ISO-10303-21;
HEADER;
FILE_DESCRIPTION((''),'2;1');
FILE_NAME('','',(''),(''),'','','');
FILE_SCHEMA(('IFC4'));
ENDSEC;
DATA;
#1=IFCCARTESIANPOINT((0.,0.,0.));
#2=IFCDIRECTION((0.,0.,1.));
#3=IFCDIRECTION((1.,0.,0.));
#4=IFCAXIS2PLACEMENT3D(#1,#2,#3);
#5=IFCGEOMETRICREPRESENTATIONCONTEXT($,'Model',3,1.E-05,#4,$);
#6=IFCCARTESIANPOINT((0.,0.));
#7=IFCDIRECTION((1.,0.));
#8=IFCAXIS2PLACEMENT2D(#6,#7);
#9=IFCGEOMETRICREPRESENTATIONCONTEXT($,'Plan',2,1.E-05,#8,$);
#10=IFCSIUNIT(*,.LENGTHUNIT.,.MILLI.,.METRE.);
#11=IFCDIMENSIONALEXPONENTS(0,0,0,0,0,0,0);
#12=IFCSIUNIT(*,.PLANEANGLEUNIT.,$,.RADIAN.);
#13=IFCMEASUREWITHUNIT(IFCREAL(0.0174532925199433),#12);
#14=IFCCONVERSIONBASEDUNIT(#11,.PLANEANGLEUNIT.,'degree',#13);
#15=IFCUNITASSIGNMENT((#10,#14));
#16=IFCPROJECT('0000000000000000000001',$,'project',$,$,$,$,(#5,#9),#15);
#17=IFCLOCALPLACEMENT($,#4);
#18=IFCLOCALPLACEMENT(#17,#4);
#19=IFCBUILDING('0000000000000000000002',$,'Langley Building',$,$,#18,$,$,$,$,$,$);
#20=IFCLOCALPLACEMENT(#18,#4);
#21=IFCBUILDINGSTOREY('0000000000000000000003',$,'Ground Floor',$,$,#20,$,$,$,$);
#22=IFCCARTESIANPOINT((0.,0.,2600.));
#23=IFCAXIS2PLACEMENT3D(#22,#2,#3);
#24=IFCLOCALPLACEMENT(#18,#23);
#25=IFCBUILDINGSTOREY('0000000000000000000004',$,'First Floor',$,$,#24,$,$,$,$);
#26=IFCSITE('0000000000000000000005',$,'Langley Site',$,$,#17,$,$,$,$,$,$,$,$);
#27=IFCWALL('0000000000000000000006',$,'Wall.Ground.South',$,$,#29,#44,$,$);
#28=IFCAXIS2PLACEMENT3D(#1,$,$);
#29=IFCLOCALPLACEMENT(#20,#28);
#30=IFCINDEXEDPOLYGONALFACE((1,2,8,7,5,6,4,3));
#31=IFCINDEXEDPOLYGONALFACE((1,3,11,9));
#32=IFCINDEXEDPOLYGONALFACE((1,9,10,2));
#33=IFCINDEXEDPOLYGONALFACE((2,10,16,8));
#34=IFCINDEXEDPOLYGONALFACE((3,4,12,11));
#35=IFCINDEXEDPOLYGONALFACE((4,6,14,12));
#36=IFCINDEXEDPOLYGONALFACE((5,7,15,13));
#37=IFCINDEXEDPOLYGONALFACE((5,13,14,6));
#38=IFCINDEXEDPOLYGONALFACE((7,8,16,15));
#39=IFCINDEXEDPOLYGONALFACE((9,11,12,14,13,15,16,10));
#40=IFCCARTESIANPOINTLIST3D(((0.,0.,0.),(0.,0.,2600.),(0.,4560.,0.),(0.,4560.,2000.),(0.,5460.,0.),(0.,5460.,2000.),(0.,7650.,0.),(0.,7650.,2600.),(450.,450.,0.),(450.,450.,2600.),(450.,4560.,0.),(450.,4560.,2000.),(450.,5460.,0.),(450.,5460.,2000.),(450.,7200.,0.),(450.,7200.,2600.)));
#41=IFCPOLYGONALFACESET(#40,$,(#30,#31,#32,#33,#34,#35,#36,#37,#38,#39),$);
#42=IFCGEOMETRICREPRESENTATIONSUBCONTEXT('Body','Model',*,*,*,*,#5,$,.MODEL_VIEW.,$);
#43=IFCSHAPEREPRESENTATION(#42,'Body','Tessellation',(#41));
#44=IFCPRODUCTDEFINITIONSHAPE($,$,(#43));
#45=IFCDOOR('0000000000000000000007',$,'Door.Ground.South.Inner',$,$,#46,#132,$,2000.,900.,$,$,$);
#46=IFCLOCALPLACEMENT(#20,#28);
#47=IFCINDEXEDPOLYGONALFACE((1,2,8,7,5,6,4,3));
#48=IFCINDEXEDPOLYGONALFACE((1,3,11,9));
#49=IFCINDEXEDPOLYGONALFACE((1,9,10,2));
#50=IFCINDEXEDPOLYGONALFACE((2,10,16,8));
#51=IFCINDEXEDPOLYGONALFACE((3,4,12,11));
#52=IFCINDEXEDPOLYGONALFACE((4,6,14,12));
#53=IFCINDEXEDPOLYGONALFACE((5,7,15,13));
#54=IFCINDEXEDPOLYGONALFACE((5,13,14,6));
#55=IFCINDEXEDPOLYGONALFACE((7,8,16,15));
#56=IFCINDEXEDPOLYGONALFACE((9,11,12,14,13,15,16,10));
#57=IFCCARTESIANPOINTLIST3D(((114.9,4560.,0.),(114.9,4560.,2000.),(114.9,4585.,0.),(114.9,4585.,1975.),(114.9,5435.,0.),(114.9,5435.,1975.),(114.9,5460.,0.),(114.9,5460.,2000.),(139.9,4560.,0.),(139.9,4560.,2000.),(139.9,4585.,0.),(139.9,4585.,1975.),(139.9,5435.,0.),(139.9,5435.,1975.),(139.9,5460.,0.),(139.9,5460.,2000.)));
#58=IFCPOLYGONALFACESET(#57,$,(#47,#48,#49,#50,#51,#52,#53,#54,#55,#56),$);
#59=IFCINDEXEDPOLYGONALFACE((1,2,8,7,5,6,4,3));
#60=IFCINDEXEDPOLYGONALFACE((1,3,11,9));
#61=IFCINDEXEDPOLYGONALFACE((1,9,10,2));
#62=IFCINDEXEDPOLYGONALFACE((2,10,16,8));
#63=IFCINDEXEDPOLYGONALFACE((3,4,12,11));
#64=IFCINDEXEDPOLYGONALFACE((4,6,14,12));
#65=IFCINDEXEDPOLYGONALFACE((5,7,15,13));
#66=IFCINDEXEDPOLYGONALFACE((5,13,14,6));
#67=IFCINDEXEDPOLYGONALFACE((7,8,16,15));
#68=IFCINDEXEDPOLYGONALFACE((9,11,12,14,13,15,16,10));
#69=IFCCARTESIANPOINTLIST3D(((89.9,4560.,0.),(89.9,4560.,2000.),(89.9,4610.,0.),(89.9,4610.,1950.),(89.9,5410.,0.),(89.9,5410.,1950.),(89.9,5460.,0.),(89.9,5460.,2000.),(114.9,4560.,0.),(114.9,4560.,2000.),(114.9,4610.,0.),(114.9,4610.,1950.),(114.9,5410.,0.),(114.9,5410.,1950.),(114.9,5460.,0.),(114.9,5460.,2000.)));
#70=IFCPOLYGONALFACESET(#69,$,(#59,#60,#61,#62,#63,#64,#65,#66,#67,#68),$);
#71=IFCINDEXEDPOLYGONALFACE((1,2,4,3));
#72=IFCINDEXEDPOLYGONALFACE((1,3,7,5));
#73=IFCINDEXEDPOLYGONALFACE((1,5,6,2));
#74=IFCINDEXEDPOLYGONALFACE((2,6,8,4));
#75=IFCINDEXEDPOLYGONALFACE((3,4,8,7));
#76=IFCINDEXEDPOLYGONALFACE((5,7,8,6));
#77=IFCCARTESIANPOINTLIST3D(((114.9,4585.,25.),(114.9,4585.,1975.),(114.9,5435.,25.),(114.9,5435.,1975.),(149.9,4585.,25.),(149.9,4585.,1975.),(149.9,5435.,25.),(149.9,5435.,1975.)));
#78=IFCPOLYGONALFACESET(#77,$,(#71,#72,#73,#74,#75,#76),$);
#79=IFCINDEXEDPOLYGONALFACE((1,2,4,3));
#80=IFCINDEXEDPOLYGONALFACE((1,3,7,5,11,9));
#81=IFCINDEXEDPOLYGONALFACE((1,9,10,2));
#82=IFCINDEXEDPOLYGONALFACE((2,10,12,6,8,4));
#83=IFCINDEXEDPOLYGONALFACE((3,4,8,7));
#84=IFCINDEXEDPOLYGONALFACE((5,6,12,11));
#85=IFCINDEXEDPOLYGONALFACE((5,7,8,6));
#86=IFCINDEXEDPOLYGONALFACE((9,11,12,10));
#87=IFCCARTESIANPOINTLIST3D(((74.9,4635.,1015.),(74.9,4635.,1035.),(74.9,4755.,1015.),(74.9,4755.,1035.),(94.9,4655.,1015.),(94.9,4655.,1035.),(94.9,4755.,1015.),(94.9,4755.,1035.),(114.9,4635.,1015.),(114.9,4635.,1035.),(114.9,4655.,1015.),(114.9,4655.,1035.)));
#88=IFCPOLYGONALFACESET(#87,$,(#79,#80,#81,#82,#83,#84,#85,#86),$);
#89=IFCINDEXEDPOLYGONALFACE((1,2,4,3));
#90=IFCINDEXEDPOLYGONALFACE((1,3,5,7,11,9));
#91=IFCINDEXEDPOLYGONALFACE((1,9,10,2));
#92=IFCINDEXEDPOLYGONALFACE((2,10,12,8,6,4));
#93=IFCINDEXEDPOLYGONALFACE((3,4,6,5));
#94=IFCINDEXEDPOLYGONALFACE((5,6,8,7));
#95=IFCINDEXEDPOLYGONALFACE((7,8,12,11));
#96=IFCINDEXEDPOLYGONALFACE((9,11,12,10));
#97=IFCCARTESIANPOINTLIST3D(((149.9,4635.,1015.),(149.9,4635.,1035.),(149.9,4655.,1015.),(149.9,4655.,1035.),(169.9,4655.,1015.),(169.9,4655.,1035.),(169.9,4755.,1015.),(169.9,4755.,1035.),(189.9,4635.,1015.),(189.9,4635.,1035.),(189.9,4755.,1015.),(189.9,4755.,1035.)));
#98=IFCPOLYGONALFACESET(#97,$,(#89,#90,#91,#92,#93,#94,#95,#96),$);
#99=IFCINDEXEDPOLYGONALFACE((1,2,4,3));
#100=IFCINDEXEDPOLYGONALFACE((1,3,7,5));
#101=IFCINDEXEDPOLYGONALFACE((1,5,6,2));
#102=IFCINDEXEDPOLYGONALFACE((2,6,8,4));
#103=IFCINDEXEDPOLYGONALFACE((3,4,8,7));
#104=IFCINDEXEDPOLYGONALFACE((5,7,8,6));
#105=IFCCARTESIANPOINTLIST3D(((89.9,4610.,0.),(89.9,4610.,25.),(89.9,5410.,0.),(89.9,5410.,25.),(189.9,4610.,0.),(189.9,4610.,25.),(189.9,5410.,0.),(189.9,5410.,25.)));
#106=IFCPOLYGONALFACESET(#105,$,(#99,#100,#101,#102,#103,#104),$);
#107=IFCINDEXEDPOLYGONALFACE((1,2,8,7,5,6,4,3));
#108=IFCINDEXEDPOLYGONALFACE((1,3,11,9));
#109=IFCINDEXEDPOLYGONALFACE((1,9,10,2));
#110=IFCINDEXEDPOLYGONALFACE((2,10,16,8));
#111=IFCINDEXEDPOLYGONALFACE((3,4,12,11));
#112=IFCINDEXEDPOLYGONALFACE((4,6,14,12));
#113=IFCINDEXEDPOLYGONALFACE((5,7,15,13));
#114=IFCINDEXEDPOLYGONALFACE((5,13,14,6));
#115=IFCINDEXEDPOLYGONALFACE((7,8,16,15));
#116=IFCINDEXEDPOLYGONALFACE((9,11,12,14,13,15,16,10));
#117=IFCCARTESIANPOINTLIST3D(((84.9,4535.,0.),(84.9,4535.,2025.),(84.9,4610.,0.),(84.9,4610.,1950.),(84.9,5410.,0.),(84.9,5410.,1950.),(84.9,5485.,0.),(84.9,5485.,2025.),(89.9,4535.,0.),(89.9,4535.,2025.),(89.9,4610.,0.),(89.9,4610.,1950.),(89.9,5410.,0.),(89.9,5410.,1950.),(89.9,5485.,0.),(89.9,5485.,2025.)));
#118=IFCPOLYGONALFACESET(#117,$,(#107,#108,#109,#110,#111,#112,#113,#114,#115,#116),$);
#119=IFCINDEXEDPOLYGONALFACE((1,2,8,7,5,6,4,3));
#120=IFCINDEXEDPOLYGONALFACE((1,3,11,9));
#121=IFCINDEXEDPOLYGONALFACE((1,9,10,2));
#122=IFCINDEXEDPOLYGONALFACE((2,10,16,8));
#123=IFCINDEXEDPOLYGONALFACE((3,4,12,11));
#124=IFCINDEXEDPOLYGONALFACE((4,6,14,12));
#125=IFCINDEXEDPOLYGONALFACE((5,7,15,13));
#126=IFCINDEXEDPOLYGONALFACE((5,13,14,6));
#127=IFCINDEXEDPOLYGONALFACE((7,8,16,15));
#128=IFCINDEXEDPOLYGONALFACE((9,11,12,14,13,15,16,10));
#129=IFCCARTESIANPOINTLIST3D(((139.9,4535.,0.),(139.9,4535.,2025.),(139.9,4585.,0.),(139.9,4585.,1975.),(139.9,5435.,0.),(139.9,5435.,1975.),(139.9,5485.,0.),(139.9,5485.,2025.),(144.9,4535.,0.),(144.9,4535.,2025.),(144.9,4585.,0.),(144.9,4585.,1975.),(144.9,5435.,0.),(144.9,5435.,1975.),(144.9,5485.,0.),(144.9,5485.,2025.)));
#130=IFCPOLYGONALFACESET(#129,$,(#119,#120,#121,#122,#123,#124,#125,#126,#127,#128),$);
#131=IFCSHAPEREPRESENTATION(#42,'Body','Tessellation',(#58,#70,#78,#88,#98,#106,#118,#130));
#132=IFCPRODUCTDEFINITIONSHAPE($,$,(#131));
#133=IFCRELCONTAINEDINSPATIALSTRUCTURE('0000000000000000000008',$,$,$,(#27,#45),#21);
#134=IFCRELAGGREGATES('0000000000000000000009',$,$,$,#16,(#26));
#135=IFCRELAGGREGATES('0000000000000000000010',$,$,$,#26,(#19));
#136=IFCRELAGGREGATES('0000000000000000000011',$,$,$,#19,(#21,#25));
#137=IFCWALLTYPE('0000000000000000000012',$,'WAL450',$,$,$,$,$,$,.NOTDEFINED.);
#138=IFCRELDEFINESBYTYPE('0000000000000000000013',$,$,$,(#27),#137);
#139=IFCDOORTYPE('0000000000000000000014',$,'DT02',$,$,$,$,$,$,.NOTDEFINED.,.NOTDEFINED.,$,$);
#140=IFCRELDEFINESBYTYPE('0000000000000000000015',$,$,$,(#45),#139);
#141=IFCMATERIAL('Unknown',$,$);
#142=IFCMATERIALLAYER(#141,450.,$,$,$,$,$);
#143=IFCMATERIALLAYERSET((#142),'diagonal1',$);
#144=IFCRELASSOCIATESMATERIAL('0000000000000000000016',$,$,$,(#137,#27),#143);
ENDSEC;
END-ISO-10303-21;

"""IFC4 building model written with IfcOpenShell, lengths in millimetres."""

from ifc_helpers import new_model, entity, si_unit, converted_unit, frame, origin_with_axes, origin_2d_with_axis, place, context, subcontext, project, spatial, line, indexed_curve, outline, extrude, shape, source, transform, mapped, material, layer, layer_set, layer_usage, type_object, type_shapes, element, fill, save


model = new_model("IFC4")

# Units and contexts
model_context = context("Model", 3, precision=1e-05, world=origin_with_axes())
plan_context = context("Plan", 2, precision=1e-05, world=origin_2d_with_axis())
body_context_1 = subcontext(model_context, "Body", "Model", "MODEL_VIEW")
body_context_2 = subcontext(plan_context, "Body", "Plan", "PLAN_VIEW")
ifc_project = project(units=[si_unit("LENGTHUNIT", "METRE", prefix="MILLI"), converted_unit("PLANEANGLEUNIT", "degree", entity("IfcReal", 0.0174532925199433), si_unit("PLANEANGLEUNIT", "RADIAN"), dimensions=[0, 0, 0, 0, 0, 0, 0])], contexts=[model_context, plan_context])

# Site, building, storey
site_placement = place(None, origin_with_axes())
site = spatial("IfcSite", under=ifc_project, at=site_placement, Name="Langley Site")
building_placement = place(site_placement, origin_with_axes())
building = spatial("IfcBuilding", under=site, at=building_placement, Name="Langley Building")
storey_1_placement = place(building_placement, origin_with_axes())
storey_1 = spatial("IfcBuildingStorey", under=building, at=storey_1_placement, Name="Ground Floor")

# Shared definitions
ifc_material = material(Name="Unknown")
shared_shape_1 = source(origin_with_axes(), body_context_1, "Body", "SweptSolid", [
    extrude(outline(indexed_curve([(0.0, 0.0), (900.0, 0.0), (900.0, 2000.0), (0.0, 2000.0)], segments=[line(1, 2, 3, 4, 1)])), frame((0.0, -600.0, 0.0), z_axis=(0.0, -1.0, 0.0), x_axis=(1.0, 0.0, 0.0)), (0.0, 0.0, -1.0), 1200.0),
])
door_type_1 = type_object("IfcDoorType", Name="DT02", OperationType="NOTDEFINED", PredefinedType="NOTDEFINED")
shared_shape_2 = source(origin_with_axes(), body_context_1, "Body", "SweptSolid", [
    extrude(outline(indexed_curve([(0.0, 0.0), (0.0, 2000.0), (900.0, 2000.0), (900.0, 0.0), (875.0, 0.0), (875.0, 1975.0), (25.0, 1975.0), (25.0, 0.0)], segments=[line(1, 2, 3, 4, 5, 6, 7, 8, 1)])), frame((0.0, 25.0, 0.0), z_axis=(0.0, -1.0, 0.0), x_axis=(1.0, 0.0, 0.0)), (0.0, 0.0, -1.0), 25.0),
    extrude(outline(indexed_curve([(0.0, 0.0), (0.0, 2000.0), (900.0, 2000.0), (900.0, 0.0), (850.0, 0.0), (850.0, 1950.0), (50.0, 1950.0), (50.0, 0.0)], segments=[line(1, 2, 3, 4, 5, 6, 7, 8, 1)])), frame((0.0, 0.0, 0.0), z_axis=(0.0, -1.0, 0.0), x_axis=(1.0, 0.0, 0.0)), (0.0, 0.0, -1.0), 25.0),
    extrude(outline(indexed_curve([(0.0, 0.0), (850.0, 0.0), (850.0, 35.0), (0.0, 35.0)], segments=[line(1, 2, 3, 4, 1)])), frame((25.0, 25.0, 25.0), z_axis=(0.0, 0.0, 1.0), x_axis=(1.0, 0.0, 0.0)), (0.0, 0.0, 1.0), 1950.0),
    extrude(outline(indexed_curve([(0.0, 0.0), (0.0, -40.0), (-120.0, -40.0), (-120.0, -20.0), (-20.0, -20.0), (-20.0, 0.0)], segments=[line(1, 2, 3, 4, 5, 6, 1)])), frame((825.0, 25.0, 1015.0), z_axis=(0.0, 0.0, 1.0), x_axis=(1.0, 0.0, 0.0)), (0.0, 0.0, 1.0), 20.0),
    extrude(outline(indexed_curve([(0.0, 0.0), (0.0, 40.0), (-120.0, 40.0), (-120.0, 20.0), (-20.0, 20.0), (-20.0, 0.0)], segments=[line(1, 2, 3, 4, 5, 6, 1)])), frame((825.0, 60.0, 1015.0), z_axis=(0.0, 0.0, 1.0), x_axis=(1.0, 0.0, 0.0)), (0.0, 0.0, 1.0), 20.0),
    extrude(outline(indexed_curve([(0.0, 0.0), (800.0, 0.0), (800.0, 100.0), (0.0, 100.0)], segments=[line(1, 2, 3, 4, 1)])), frame((50.0, 0.0, 0.0), z_axis=(0.0, 0.0, 1.0), x_axis=(1.0, 0.0, 0.0)), (0.0, 0.0, 1.0), 25.0),
    extrude(outline(indexed_curve([(0.0, 0.0), (0.0, 2025.0), (950.0, 2025.0), (950.0, 0.0), (875.0, 0.0), (875.0, 1950.0), (75.0, 1950.0), (75.0, 0.0)], segments=[line(1, 2, 3, 4, 5, 6, 7, 8, 1)])), frame((-25.0, -5.0, 0.0), z_axis=(0.0, -1.0, 0.0), x_axis=(1.0, 0.0, 0.0)), (0.0, 0.0, -1.0), 5.0),
    extrude(outline(indexed_curve([(0.0, 0.0), (0.0, 2025.0), (950.0, 2025.0), (950.0, 0.0), (900.0, 0.0), (900.0, 1975.0), (50.0, 1975.0), (50.0, 0.0)], segments=[line(1, 2, 3, 4, 5, 6, 7, 8, 1)])), frame((-25.0, 50.0, 0.0), z_axis=(0.0, -1.0, 0.0), x_axis=(1.0, 0.0, 0.0)), (0.0, 0.0, -1.0), 5.0),
])
shared_shape_3 = source(origin_with_axes(), body_context_2, "Body", "Curve2D", [
    entity("IfcIndexedPolyCurve", entity("IfcCartesianPointList2D", [[0.0, 0.0], [0.0, 50.0], [25.0, 50.0], [25.0, 25.0], [50.0, 25.0], [50.0, 0.0]]), [entity("IfcLineIndex", [1, 2, 3, 4, 5, 6, 1])]),
    entity("IfcIndexedPolyCurve", entity("IfcCartesianPointList2D", [[900.0, 0.0], [900.0, 50.0], [875.0, 50.0], [875.0, 25.0], [850.0, 25.0], [850.0, 0.0]]), [entity("IfcLineIndex", [1, 2, 3, 4, 5, 6, 1])]),
    entity("IfcTrimmedCurve", entity("IfcEllipse", entity("IfcAxis2Placement2D", entity("IfcCartesianPoint", [60.0, 50.0]), entity("IfcDirection", [1.0, 0.0])), 815.0, 850.0), [entity("IfcCartesianPoint", [875.0, 50.0])], [entity("IfcCartesianPoint", [60.0, 900.0])], True, "CARTESIAN"),
    entity("IfcIndexedPolyCurve", entity("IfcCartesianPointList2D", [[25.0, 50.0], [60.0, 50.0], [60.0, 900.0], [25.0, 900.0]]), [entity("IfcLineIndex", [1, 2, 3, 4, 1])]),
])
type_shapes(door_type_1, [shared_shape_2, shared_shape_3])

# Shared definitions
storey_2_placement = place(building_placement, frame((0.0, 0.0, 2600.0), z_axis=(0.0, 0.0, 1.0), x_axis=(1.0, 0.0, 0.0)))
storey_2 = spatial("IfcBuildingStorey", under=building, at=storey_2_placement, Name="First Floor")

# Shared definitions
ifc_layer_1 = layer(ifc_material, 450.0)
ifc_layer_set_1 = layer_set([ifc_layer_1], Name="diagonal1")
wall_type_1 = type_object("IfcWallType", Name="WAL450", PredefinedType="NOTDEFINED", material=ifc_layer_set_1)

# Wall, opening, door
ifc_layer_usage_1 = layer_usage(ifc_layer_set_1, "AXIS2", "POSITIVE", 0.0)
wall_1_placement = place(storey_1_placement, frame((0.0, 7650.0, 0.0), z_axis=(0.0, 0.0, 1.0), x_axis=(0.0, -1.0, 0.0)))
wall_1 = element("IfcWall", 1, at=wall_1_placement, inside=storey_1, type_object=wall_type_1, material=ifc_layer_usage_1, Name="Wall.Ground.South", context=body_context_1, shape_type="SweptSolid", body=[
    extrude(outline(indexed_curve([(0.0, 0.0), (450.0, 450.0), (7200.0, 450.0), (7650.0, 0.0)], segments=[line(1, 2, 3, 4, 1)])), origin_with_axes(), (0.0, 0.0, 1.0), 2600.0),
])
opening_1_placement = place(wall_1_placement, frame((2190.0, 89.9, 0.0), z_axis=(0.0, 0.0, 1.0), x_axis=(1.0, 0.0, 0.0)))
opening_1 = element("IfcOpeningElement", 2, at=opening_1_placement, cuts=wall_1, PredefinedType="OPENING", context=body_context_1, shape_type="MappedRepresentation", body=[
    mapped(shared_shape_1, transform((0.0, 0.0, 0.0), x_axis=(1.0, 0.0, 0.0), y_axis=(0.0, 1.0, 0.0), z_axis=(0.0, 0.0, 1.0), scale=1.0)),
])
door_1_placement = place(opening_1_placement, origin_with_axes())
door_1 = element("IfcDoor", 3, at=door_1_placement, inside=storey_1, type_object=door_type_1, Name="Door.Ground.South.Inner", OverallHeight=2000.0, OverallWidth=900.0, shapes=[
    shape(body_context_1, "Body", "MappedRepresentation", [mapped(shared_shape_2, transform((0.0, 0.0, 0.0), x_axis=(1.0, 0.0, 0.0), y_axis=(0.0, 1.0, 0.0), z_axis=(0.0, 0.0, 1.0), scale=1.0))]),
    shape(body_context_2, "Body", "MappedRepresentation", [mapped(shared_shape_3, transform((0.0, 0.0, 0.0), x_axis=(1.0, 0.0, 0.0), y_axis=(0.0, 1.0, 0.0), z_axis=(0.0, 0.0, 1.0), scale=1.0))]),
])
fill(opening_1, door_1)

save(model, "model.ifc")
